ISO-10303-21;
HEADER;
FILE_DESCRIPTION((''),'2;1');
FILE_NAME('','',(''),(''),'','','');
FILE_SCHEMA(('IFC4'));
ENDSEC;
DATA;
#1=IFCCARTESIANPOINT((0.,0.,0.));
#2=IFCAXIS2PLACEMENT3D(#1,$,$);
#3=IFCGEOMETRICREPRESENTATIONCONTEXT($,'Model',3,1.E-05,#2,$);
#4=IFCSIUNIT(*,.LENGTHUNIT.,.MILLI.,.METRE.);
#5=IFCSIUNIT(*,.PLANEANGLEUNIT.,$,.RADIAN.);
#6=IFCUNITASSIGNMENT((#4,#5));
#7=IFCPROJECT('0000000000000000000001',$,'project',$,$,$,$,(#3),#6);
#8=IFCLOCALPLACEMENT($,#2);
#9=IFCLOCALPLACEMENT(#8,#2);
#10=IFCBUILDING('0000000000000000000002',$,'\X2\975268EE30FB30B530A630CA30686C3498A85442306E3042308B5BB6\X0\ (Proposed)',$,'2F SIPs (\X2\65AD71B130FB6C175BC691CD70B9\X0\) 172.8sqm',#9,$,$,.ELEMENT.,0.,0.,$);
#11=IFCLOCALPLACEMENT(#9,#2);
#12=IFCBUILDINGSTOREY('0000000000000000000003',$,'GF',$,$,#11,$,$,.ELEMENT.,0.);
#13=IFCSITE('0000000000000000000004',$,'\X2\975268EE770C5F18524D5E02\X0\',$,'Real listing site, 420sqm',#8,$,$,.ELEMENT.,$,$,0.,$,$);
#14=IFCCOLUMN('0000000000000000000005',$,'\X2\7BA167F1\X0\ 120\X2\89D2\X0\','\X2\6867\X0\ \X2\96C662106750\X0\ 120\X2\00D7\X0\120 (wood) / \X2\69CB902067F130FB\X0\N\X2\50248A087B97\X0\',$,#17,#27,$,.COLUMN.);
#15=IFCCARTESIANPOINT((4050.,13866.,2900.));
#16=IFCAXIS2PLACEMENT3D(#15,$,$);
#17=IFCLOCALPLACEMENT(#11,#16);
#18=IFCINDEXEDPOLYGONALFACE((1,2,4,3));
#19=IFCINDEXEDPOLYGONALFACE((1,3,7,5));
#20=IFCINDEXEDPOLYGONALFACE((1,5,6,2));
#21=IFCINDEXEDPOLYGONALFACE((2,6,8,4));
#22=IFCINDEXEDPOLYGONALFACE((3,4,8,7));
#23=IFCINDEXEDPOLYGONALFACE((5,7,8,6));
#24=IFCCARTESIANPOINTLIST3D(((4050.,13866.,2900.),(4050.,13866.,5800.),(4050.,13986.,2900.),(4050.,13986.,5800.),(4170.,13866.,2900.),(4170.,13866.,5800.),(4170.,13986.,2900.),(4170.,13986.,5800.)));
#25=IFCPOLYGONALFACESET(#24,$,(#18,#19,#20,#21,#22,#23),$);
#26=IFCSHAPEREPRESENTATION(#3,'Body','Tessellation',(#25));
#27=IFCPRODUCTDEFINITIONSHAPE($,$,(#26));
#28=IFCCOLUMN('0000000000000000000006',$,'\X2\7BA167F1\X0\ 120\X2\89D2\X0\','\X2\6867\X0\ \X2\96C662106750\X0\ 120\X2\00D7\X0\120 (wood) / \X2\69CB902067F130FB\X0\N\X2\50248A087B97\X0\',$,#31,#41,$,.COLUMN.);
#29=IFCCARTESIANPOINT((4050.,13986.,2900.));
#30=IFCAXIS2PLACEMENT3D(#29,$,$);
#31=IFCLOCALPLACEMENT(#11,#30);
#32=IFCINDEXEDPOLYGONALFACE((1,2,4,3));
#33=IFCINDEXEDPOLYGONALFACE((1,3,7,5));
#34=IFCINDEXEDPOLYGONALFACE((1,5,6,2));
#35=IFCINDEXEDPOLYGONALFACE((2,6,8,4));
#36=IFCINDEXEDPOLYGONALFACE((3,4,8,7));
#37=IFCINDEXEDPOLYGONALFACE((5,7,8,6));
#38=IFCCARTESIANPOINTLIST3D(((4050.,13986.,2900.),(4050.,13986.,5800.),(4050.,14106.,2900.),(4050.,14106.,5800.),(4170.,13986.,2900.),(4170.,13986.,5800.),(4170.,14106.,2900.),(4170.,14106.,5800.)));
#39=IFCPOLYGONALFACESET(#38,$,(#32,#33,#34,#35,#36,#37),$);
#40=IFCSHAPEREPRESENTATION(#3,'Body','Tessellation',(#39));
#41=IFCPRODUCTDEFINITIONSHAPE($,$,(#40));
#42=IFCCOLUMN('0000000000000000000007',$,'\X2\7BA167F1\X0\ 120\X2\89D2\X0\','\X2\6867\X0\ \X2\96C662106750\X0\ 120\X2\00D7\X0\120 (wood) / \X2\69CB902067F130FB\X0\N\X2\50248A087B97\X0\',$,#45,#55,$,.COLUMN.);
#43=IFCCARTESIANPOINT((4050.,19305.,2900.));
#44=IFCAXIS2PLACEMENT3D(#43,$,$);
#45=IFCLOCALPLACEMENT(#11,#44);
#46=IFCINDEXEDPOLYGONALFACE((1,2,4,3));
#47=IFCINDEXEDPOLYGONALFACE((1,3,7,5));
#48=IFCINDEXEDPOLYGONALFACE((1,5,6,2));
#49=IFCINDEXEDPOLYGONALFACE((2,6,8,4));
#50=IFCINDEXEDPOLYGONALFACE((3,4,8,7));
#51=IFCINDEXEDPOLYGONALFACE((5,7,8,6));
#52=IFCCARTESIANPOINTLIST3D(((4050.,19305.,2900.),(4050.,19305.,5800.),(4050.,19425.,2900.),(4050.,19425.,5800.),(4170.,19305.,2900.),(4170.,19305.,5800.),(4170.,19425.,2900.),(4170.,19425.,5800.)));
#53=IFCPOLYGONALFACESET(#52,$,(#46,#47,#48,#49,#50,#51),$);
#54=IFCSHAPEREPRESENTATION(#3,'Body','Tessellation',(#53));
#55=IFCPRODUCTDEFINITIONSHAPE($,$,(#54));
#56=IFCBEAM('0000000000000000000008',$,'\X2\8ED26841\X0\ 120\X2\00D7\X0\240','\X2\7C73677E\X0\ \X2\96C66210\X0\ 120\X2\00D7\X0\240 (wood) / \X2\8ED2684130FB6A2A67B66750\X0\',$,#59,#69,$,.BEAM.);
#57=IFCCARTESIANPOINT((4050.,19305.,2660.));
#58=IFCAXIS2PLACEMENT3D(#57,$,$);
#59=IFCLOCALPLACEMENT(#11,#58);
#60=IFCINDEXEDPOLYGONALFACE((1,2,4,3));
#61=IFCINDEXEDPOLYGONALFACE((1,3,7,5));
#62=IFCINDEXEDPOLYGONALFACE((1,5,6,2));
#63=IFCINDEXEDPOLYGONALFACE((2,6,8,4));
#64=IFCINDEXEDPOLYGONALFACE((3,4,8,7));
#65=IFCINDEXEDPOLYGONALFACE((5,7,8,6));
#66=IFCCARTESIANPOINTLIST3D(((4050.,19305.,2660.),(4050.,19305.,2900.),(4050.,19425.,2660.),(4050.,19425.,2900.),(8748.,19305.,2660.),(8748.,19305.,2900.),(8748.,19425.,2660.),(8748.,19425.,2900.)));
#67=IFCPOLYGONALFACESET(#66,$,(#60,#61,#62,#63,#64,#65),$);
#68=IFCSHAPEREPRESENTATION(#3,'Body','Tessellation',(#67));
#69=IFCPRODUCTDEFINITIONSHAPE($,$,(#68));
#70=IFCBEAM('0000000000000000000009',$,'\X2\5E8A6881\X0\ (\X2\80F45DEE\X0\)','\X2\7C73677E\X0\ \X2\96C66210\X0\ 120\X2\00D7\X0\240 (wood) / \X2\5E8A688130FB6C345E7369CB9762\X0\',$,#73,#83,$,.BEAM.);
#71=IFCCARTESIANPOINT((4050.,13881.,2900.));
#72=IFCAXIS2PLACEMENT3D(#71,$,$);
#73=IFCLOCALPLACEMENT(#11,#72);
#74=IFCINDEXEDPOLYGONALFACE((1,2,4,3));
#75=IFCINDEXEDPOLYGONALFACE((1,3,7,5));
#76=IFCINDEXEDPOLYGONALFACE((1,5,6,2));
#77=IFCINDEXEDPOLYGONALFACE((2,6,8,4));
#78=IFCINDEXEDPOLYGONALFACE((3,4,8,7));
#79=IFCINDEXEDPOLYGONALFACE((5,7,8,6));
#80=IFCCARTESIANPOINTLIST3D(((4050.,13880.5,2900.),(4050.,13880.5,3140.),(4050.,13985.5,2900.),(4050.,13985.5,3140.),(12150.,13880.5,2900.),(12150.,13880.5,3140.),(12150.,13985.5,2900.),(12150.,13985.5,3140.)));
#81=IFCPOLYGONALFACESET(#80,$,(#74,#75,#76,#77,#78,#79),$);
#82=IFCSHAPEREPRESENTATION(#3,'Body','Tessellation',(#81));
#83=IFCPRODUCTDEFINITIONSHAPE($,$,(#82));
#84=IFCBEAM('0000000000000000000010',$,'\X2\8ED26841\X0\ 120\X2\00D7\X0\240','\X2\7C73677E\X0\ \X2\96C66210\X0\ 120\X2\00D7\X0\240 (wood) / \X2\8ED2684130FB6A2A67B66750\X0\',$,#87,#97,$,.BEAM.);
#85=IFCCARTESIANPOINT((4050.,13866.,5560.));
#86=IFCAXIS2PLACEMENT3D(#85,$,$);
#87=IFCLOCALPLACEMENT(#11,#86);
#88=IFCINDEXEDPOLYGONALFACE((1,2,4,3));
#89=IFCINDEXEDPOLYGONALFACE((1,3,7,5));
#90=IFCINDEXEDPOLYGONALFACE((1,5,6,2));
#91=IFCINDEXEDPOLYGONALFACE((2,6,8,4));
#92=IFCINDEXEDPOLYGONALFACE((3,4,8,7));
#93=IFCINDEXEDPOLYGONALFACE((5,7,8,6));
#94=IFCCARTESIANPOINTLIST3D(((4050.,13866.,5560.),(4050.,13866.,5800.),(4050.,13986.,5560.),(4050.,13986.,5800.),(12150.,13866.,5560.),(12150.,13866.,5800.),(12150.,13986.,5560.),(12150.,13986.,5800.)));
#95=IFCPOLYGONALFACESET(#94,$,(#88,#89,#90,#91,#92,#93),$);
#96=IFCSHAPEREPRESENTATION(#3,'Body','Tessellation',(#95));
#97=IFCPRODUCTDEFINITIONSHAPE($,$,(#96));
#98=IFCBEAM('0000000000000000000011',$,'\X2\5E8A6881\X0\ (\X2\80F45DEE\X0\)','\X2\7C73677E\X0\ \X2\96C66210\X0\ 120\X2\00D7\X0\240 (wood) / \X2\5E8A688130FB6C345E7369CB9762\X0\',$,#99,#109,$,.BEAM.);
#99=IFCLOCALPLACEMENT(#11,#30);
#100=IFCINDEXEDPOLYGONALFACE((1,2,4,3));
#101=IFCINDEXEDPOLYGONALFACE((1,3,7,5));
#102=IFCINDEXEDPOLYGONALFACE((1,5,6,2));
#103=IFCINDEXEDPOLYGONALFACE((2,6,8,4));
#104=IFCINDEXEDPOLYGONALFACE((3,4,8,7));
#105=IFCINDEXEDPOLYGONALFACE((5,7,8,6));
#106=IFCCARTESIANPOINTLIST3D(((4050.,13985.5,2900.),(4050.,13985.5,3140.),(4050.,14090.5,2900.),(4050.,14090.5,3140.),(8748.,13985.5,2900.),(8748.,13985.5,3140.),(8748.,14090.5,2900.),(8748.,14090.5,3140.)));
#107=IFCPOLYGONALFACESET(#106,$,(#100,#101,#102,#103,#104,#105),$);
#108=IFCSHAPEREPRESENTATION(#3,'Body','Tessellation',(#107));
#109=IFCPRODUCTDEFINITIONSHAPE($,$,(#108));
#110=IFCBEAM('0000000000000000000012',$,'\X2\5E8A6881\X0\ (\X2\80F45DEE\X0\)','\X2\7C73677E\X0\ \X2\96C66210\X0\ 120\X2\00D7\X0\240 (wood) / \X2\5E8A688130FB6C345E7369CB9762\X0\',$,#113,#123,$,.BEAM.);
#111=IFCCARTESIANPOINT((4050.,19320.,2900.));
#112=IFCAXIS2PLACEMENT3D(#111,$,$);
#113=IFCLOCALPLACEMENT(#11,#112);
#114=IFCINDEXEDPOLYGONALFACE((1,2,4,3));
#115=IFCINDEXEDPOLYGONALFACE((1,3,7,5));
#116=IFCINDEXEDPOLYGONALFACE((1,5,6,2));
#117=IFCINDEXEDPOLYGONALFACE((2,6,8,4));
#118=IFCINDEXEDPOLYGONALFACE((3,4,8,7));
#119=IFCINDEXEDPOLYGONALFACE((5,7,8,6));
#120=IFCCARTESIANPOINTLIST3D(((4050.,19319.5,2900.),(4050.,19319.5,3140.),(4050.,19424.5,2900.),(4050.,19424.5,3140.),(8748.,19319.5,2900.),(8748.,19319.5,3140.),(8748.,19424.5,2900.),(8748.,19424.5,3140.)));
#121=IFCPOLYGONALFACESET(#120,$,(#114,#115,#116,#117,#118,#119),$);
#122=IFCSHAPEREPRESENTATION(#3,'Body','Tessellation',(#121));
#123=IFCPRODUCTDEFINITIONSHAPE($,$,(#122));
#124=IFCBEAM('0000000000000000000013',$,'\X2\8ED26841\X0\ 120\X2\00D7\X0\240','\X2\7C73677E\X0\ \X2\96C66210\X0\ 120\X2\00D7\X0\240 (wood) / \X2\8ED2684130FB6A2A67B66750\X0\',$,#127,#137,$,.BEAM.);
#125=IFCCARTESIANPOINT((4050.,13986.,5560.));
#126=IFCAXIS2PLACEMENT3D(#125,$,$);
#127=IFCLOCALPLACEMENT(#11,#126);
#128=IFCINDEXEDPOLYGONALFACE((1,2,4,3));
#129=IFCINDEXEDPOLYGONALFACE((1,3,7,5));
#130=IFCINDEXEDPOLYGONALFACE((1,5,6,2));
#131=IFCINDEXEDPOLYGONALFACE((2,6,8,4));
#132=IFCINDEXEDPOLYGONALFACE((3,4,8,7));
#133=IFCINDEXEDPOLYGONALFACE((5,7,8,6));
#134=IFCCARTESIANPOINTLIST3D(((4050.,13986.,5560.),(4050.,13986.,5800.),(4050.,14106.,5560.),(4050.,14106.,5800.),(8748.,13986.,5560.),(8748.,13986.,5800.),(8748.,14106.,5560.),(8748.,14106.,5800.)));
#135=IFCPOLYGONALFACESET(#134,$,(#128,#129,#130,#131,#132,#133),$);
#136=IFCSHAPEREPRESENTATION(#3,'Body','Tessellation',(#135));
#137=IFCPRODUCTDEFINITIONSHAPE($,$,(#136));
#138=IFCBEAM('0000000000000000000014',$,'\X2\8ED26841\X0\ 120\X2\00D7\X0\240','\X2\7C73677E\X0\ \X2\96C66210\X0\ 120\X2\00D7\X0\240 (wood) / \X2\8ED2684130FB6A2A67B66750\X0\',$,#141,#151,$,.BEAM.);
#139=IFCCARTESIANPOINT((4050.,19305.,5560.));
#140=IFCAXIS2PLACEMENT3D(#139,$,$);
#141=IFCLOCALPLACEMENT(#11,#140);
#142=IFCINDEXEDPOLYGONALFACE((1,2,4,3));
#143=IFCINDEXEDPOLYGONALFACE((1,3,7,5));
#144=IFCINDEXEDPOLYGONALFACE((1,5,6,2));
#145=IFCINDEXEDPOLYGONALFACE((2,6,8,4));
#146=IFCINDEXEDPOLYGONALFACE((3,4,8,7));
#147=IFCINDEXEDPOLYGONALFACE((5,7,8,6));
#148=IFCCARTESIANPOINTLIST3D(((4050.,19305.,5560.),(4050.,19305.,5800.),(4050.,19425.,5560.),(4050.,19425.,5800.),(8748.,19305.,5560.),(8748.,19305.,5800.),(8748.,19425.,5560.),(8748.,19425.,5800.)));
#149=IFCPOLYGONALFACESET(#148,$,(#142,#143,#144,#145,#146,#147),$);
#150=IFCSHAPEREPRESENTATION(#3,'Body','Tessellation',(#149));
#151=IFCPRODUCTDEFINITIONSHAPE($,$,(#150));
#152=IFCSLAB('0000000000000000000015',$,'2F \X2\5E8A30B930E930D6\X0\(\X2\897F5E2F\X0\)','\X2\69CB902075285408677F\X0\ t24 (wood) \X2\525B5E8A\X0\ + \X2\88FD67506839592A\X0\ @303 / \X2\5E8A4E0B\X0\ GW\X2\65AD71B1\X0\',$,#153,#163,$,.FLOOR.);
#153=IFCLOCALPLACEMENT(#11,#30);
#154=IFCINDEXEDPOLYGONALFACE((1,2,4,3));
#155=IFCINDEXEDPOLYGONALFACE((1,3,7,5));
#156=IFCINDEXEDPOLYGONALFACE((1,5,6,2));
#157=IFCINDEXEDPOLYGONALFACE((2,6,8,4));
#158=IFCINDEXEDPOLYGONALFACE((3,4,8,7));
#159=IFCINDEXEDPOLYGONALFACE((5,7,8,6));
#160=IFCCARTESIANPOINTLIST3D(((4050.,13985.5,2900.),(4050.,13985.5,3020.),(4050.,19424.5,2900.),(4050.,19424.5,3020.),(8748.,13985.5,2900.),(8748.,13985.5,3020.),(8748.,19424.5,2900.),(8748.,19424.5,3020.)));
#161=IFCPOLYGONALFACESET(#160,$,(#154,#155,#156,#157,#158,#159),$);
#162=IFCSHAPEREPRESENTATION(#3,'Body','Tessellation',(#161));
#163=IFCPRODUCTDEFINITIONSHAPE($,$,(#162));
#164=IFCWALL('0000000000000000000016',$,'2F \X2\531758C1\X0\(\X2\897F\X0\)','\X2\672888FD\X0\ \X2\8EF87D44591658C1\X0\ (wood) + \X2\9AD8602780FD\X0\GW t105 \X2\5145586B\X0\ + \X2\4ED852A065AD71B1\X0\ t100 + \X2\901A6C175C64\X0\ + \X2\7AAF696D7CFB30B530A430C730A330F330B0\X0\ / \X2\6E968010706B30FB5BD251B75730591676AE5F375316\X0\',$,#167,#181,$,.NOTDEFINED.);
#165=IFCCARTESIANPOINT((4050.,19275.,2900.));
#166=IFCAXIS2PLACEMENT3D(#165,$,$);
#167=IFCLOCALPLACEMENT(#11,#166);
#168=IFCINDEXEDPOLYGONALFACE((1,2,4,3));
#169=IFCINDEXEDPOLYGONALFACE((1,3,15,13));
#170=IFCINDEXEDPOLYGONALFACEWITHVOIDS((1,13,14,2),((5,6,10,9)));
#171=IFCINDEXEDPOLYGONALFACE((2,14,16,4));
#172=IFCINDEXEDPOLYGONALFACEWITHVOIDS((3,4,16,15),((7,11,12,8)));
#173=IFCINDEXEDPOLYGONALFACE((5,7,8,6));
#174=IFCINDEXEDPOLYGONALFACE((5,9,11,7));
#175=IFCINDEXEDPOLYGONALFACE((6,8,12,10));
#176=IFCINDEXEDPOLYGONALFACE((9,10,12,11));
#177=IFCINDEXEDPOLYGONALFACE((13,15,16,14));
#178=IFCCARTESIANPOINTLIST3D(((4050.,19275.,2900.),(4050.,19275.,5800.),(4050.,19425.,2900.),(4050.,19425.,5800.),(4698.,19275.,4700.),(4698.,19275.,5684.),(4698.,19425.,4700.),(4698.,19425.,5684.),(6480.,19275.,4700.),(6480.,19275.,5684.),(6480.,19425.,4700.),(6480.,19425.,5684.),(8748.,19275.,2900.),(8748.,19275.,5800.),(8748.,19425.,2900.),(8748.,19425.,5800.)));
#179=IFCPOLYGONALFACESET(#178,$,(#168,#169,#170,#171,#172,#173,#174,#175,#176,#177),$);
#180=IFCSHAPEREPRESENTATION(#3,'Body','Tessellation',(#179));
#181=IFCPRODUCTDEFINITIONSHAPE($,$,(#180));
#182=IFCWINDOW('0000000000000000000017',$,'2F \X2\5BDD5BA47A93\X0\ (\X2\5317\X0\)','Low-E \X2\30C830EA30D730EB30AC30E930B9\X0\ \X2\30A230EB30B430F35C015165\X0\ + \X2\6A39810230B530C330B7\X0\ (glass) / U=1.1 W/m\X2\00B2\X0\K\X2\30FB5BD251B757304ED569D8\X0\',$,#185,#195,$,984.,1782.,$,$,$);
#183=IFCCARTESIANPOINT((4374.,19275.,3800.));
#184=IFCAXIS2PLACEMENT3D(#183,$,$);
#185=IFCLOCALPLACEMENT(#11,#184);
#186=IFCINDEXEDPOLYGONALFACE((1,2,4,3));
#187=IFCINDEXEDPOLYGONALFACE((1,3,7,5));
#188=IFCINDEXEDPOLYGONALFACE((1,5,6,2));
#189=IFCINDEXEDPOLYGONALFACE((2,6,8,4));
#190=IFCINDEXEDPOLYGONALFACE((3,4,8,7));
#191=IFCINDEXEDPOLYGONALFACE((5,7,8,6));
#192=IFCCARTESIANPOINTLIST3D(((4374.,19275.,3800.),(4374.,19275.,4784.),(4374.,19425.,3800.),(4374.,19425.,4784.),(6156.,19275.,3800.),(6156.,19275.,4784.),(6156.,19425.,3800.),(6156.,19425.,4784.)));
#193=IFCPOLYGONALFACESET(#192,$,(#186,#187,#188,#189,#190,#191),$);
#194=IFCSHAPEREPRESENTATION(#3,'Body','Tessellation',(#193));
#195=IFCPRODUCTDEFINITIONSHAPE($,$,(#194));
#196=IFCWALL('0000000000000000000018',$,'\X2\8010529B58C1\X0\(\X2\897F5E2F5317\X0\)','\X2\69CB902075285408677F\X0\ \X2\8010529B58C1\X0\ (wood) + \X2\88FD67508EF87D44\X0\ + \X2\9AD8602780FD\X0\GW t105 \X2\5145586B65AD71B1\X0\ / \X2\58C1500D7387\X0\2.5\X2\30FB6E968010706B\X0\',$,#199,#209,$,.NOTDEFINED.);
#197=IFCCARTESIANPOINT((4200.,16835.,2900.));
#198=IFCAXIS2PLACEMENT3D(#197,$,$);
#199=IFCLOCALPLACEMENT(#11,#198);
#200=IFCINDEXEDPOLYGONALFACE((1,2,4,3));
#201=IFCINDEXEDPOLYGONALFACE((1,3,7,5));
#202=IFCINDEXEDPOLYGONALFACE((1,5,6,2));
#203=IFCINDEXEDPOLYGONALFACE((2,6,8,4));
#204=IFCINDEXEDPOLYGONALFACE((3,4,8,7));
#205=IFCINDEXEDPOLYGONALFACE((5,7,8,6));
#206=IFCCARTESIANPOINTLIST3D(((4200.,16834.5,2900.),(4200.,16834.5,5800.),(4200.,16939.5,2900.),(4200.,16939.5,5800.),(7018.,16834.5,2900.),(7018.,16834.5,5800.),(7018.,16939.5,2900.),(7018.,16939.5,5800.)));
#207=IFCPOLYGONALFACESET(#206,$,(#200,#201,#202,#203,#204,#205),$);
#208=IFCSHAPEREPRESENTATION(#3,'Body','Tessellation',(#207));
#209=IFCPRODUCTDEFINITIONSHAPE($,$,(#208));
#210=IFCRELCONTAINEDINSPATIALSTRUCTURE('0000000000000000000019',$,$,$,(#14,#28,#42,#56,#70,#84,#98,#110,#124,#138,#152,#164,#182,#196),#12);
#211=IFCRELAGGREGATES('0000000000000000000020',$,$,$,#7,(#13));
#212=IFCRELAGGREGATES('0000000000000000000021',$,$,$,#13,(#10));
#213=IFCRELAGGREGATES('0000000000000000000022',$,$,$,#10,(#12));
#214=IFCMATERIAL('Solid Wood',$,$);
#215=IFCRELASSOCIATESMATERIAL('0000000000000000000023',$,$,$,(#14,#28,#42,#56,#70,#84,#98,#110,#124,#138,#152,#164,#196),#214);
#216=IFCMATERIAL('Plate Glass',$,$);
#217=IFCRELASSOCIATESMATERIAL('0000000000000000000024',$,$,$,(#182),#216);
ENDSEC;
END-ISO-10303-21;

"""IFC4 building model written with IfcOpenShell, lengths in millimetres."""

from ifc_helpers import new_model, si_unit, frame, frame_2d, origin, place, context, project, spatial, rectangle, extrude, material, element, fill, save


model = new_model("IFC4")

# Units and contexts
model_context = context("Model", 3, precision=1e-05, world=origin())
ifc_project = project(units=[si_unit("LENGTHUNIT", "METRE", prefix="MILLI"), si_unit("PLANEANGLEUNIT", "RADIAN")], contexts=[model_context])

# Site, building, storey
site_placement = place(None, origin())
site = spatial("IfcSite", under=ifc_project, at=site_placement, Name="青森県弘前市", ObjectType="Real listing site, 420sqm", CompositionType="ELEMENT", RefElevation=0.0)
building_placement = place(site_placement, origin())
building = spatial("IfcBuilding", under=site, at=building_placement, Name="青森・サウナと水風呂のある家 (Proposed)", ObjectType="2F SIPs (断熱・気密重点) 172.8sqm", CompositionType="ELEMENT", ElevationOfRefHeight=0.0, ElevationOfTerrain=0.0)
storey_placement = place(building_placement, origin())
storey = spatial("IfcBuildingStorey", under=building, at=storey_placement, Name="GF", CompositionType="ELEMENT", Elevation=0.0)

# Columns
ifc_material_1 = material(Name="Solid Wood")
column_1_placement = place(storey_placement, frame((4050.0, 13866.0, 2900.0)))
element("IfcColumn", 1, at=column_1_placement, inside=storey, material=ifc_material_1, Name="管柱 120角", Description="桧 集成材 120×120 (wood) / 構造柱・N値計算", PredefinedType="COLUMN", context=model_context, shape_type="SweptSolid", body=[
    extrude(rectangle(XDim=120.0, YDim=120.0, at=frame_2d((60.0, 60.0))), frame((4050.0, 13866.0, 2900.0)), (0.0, 0.0, 1.0), 2900.0),
])
column_2_placement = place(storey_placement, frame((4050.0, 13986.0, 2900.0)))
element("IfcColumn", 2, at=column_2_placement, inside=storey, material=ifc_material_1, Name="管柱 120角", Description="桧 集成材 120×120 (wood) / 構造柱・N値計算", PredefinedType="COLUMN", context=model_context, shape_type="SweptSolid", body=[
    extrude(rectangle(XDim=120.0, YDim=120.0, at=frame_2d((60.0, 60.0))), frame((4050.0, 13986.0, 2900.0)), (0.0, 0.0, 1.0), 2900.0),
])
column_3_placement = place(storey_placement, frame((4050.0, 19305.0, 2900.0)))
element("IfcColumn", 3, at=column_3_placement, inside=storey, material=ifc_material_1, Name="管柱 120角", Description="桧 集成材 120×120 (wood) / 構造柱・N値計算", PredefinedType="COLUMN", context=model_context, shape_type="SweptSolid", body=[
    extrude(rectangle(XDim=120.0, YDim=120.0, at=frame_2d((60.0, 60.0))), frame((4050.0, 19305.0, 2900.0)), (0.0, 0.0, 1.0), 2900.0),
])

# Beams
beam_1_placement = place(storey_placement, frame((4050.0, 19305.0, 2660.0)))
element("IfcBeam", 4, at=beam_1_placement, inside=storey, material=ifc_material_1, Name="軒桁 120×240", Description="米松 集成 120×240 (wood) / 軒桁・横架材", PredefinedType="BEAM", context=model_context, shape_type="SweptSolid", body=[
    extrude(rectangle(XDim=4698.0, YDim=120.0, at=frame_2d((2349.0, 60.0))), frame((4050.0, 19305.0, 2660.0)), (0.0, 0.0, 1.0), 240.0),
])
beam_2_placement = place(storey_placement, frame((4050.0, 13881.0, 2900.0)))
element("IfcBeam", 5, at=beam_2_placement, inside=storey, material=ifc_material_1, Name="床梁 (胴差)", Description="米松 集成 120×240 (wood) / 床梁・水平構面", PredefinedType="BEAM", context=model_context, shape_type="SweptSolid", body=[
    extrude(rectangle(XDim=8100.0, YDim=105.0, at=frame_2d((4050.0, 52.0))), frame((4050.0, 13881.0, 2900.0)), (0.0, 0.0, 1.0), 240.0),
])
beam_3_placement = place(storey_placement, frame((4050.0, 13866.0, 5560.0)))
element("IfcBeam", 6, at=beam_3_placement, inside=storey, material=ifc_material_1, Name="軒桁 120×240", Description="米松 集成 120×240 (wood) / 軒桁・横架材", PredefinedType="BEAM", context=model_context, shape_type="SweptSolid", body=[
    extrude(rectangle(XDim=8100.0, YDim=120.0, at=frame_2d((4050.0, 60.0))), frame((4050.0, 13866.0, 5560.0)), (0.0, 0.0, 1.0), 240.0),
])
beam_4_placement = place(storey_placement, frame((4050.0, 13986.0, 2900.0)))
element("IfcBeam", 7, at=beam_4_placement, inside=storey, material=ifc_material_1, Name="床梁 (胴差)", Description="米松 集成 120×240 (wood) / 床梁・水平構面", PredefinedType="BEAM", context=model_context, shape_type="SweptSolid", body=[
    extrude(rectangle(XDim=4698.0, YDim=105.0, at=frame_2d((2349.0, 52.0))), frame((4050.0, 13986.0, 2900.0)), (0.0, 0.0, 1.0), 240.0),
])
beam_5_placement = place(storey_placement, frame((4050.0, 19320.0, 2900.0)))
element("IfcBeam", 8, at=beam_5_placement, inside=storey, material=ifc_material_1, Name="床梁 (胴差)", Description="米松 集成 120×240 (wood) / 床梁・水平構面", PredefinedType="BEAM", context=model_context, shape_type="SweptSolid", body=[
    extrude(rectangle(XDim=4698.0, YDim=105.0, at=frame_2d((2349.0, 52.0))), frame((4050.0, 19320.0, 2900.0)), (0.0, 0.0, 1.0), 240.0),
])
beam_6_placement = place(storey_placement, frame((4050.0, 13986.0, 5560.0)))
element("IfcBeam", 9, at=beam_6_placement, inside=storey, material=ifc_material_1, Name="軒桁 120×240", Description="米松 集成 120×240 (wood) / 軒桁・横架材", PredefinedType="BEAM", context=model_context, shape_type="SweptSolid", body=[
    extrude(rectangle(XDim=4698.0, YDim=120.0, at=frame_2d((2349.0, 60.0))), frame((4050.0, 13986.0, 5560.0)), (0.0, 0.0, 1.0), 240.0),
])
beam_7_placement = place(storey_placement, frame((4050.0, 19305.0, 5560.0)))
element("IfcBeam", 10, at=beam_7_placement, inside=storey, material=ifc_material_1, Name="軒桁 120×240", Description="米松 集成 120×240 (wood) / 軒桁・横架材", PredefinedType="BEAM", context=model_context, shape_type="SweptSolid", body=[
    extrude(rectangle(XDim=4698.0, YDim=120.0, at=frame_2d((2349.0, 60.0))), frame((4050.0, 19305.0, 5560.0)), (0.0, 0.0, 1.0), 240.0),
])

# Slab
slab_placement = place(storey_placement, frame((4050.0, 13986.0, 2900.0)))
element("IfcSlab", 11, at=slab_placement, inside=storey, material=ifc_material_1, Name="2F 床スラブ(西帯)", Description="構造用合板 t24 (wood) 剛床 + 製材根太 @303 / 床下 GW断熱", PredefinedType="FLOOR", context=model_context, shape_type="SweptSolid", body=[
    extrude(rectangle(XDim=4698.0, YDim=5439.0, at=frame_2d((2349.0, 2719.0))), frame((4050.0, 13986.0, 2900.0)), (0.0, 0.0, 1.0), 120.0),
])

# Wall, opening, window
wall_1_placement = place(storey_placement, frame((4050.0, 19275.0, 2900.0)))
wall_1 = element("IfcWall", 12, at=wall_1_placement, inside=storey, material=ifc_material_1, Name="2F 北壁(西)", Description="木製 軸組外壁 (wood) + 高性能GW t105 充填 + 付加断熱 t100 + 通気層 + 窯業系サイディング / 準耐火・寒冷地外皮強化", PredefinedType="NOTDEFINED", context=model_context, shape_type="SweptSolid", body=[
    extrude(rectangle(XDim=4698.0, YDim=150.0, at=frame_2d((2349.0, 75.0))), frame((4050.0, 19275.0, 2900.0)), (0.0, 0.0, 1.0), 2900.0),
])
opening_placement = place(storey_placement, frame((4374.0, 19275.0, 3800.0)))
opening = element("IfcOpeningElement", 13, at=opening_placement, cuts=wall_1, PredefinedType="NOTDEFINED", context=model_context, shape_type="SweptSolid", body=[
    extrude(rectangle(XDim=1782.0, YDim=150.0, at=frame_2d((891.0, 75.0))), frame((4374.0, 19275.0, 3800.0)), (0.0, 0.0, 1.0), 984.0),
])
ifc_material_2 = material(Name="Plate Glass")
window_placement = place(storey_placement, frame((4374.0, 19275.0, 3800.0)))
window = element("IfcWindow", 14, at=window_placement, inside=storey, material=ifc_material_2, Name="2F 寝室窓 (北)", Description="Low-E トリプルガラス アルゴン封入 + 樹脂サッシ (glass) / U=1.1 W/m²K・寒冷地仕様", OverallHeight=984.0, OverallWidth=1782.0, context=model_context, shape_type="SweptSolid", body=[
    extrude(rectangle(XDim=1782.0, YDim=150.0, at=frame_2d((891.0, 75.0))), frame((4374.0, 19275.0, 3800.0)), (0.0, 0.0, 1.0), 984.0),
])
fill(opening, window)

# Wall
wall_2_placement = place(storey_placement, frame((4200.0, 16835.0, 2900.0)))
element("IfcWall", 15, at=wall_2_placement, inside=storey, material=ifc_material_1, Name="耐力壁(西帯北)", Description="構造用合板 耐力壁 (wood) + 製材軸組 + 高性能GW t105 充填断熱 / 壁倍率2.5・準耐火", PredefinedType="NOTDEFINED", context=model_context, shape_type="SweptSolid", body=[
    extrude(rectangle(XDim=2818.0, YDim=105.0, at=frame_2d((1409.0, 52.0))), frame((4200.0, 16835.0, 2900.0)), (0.0, 0.0, 1.0), 2900.0),
])

save(model, "model.ifc")
